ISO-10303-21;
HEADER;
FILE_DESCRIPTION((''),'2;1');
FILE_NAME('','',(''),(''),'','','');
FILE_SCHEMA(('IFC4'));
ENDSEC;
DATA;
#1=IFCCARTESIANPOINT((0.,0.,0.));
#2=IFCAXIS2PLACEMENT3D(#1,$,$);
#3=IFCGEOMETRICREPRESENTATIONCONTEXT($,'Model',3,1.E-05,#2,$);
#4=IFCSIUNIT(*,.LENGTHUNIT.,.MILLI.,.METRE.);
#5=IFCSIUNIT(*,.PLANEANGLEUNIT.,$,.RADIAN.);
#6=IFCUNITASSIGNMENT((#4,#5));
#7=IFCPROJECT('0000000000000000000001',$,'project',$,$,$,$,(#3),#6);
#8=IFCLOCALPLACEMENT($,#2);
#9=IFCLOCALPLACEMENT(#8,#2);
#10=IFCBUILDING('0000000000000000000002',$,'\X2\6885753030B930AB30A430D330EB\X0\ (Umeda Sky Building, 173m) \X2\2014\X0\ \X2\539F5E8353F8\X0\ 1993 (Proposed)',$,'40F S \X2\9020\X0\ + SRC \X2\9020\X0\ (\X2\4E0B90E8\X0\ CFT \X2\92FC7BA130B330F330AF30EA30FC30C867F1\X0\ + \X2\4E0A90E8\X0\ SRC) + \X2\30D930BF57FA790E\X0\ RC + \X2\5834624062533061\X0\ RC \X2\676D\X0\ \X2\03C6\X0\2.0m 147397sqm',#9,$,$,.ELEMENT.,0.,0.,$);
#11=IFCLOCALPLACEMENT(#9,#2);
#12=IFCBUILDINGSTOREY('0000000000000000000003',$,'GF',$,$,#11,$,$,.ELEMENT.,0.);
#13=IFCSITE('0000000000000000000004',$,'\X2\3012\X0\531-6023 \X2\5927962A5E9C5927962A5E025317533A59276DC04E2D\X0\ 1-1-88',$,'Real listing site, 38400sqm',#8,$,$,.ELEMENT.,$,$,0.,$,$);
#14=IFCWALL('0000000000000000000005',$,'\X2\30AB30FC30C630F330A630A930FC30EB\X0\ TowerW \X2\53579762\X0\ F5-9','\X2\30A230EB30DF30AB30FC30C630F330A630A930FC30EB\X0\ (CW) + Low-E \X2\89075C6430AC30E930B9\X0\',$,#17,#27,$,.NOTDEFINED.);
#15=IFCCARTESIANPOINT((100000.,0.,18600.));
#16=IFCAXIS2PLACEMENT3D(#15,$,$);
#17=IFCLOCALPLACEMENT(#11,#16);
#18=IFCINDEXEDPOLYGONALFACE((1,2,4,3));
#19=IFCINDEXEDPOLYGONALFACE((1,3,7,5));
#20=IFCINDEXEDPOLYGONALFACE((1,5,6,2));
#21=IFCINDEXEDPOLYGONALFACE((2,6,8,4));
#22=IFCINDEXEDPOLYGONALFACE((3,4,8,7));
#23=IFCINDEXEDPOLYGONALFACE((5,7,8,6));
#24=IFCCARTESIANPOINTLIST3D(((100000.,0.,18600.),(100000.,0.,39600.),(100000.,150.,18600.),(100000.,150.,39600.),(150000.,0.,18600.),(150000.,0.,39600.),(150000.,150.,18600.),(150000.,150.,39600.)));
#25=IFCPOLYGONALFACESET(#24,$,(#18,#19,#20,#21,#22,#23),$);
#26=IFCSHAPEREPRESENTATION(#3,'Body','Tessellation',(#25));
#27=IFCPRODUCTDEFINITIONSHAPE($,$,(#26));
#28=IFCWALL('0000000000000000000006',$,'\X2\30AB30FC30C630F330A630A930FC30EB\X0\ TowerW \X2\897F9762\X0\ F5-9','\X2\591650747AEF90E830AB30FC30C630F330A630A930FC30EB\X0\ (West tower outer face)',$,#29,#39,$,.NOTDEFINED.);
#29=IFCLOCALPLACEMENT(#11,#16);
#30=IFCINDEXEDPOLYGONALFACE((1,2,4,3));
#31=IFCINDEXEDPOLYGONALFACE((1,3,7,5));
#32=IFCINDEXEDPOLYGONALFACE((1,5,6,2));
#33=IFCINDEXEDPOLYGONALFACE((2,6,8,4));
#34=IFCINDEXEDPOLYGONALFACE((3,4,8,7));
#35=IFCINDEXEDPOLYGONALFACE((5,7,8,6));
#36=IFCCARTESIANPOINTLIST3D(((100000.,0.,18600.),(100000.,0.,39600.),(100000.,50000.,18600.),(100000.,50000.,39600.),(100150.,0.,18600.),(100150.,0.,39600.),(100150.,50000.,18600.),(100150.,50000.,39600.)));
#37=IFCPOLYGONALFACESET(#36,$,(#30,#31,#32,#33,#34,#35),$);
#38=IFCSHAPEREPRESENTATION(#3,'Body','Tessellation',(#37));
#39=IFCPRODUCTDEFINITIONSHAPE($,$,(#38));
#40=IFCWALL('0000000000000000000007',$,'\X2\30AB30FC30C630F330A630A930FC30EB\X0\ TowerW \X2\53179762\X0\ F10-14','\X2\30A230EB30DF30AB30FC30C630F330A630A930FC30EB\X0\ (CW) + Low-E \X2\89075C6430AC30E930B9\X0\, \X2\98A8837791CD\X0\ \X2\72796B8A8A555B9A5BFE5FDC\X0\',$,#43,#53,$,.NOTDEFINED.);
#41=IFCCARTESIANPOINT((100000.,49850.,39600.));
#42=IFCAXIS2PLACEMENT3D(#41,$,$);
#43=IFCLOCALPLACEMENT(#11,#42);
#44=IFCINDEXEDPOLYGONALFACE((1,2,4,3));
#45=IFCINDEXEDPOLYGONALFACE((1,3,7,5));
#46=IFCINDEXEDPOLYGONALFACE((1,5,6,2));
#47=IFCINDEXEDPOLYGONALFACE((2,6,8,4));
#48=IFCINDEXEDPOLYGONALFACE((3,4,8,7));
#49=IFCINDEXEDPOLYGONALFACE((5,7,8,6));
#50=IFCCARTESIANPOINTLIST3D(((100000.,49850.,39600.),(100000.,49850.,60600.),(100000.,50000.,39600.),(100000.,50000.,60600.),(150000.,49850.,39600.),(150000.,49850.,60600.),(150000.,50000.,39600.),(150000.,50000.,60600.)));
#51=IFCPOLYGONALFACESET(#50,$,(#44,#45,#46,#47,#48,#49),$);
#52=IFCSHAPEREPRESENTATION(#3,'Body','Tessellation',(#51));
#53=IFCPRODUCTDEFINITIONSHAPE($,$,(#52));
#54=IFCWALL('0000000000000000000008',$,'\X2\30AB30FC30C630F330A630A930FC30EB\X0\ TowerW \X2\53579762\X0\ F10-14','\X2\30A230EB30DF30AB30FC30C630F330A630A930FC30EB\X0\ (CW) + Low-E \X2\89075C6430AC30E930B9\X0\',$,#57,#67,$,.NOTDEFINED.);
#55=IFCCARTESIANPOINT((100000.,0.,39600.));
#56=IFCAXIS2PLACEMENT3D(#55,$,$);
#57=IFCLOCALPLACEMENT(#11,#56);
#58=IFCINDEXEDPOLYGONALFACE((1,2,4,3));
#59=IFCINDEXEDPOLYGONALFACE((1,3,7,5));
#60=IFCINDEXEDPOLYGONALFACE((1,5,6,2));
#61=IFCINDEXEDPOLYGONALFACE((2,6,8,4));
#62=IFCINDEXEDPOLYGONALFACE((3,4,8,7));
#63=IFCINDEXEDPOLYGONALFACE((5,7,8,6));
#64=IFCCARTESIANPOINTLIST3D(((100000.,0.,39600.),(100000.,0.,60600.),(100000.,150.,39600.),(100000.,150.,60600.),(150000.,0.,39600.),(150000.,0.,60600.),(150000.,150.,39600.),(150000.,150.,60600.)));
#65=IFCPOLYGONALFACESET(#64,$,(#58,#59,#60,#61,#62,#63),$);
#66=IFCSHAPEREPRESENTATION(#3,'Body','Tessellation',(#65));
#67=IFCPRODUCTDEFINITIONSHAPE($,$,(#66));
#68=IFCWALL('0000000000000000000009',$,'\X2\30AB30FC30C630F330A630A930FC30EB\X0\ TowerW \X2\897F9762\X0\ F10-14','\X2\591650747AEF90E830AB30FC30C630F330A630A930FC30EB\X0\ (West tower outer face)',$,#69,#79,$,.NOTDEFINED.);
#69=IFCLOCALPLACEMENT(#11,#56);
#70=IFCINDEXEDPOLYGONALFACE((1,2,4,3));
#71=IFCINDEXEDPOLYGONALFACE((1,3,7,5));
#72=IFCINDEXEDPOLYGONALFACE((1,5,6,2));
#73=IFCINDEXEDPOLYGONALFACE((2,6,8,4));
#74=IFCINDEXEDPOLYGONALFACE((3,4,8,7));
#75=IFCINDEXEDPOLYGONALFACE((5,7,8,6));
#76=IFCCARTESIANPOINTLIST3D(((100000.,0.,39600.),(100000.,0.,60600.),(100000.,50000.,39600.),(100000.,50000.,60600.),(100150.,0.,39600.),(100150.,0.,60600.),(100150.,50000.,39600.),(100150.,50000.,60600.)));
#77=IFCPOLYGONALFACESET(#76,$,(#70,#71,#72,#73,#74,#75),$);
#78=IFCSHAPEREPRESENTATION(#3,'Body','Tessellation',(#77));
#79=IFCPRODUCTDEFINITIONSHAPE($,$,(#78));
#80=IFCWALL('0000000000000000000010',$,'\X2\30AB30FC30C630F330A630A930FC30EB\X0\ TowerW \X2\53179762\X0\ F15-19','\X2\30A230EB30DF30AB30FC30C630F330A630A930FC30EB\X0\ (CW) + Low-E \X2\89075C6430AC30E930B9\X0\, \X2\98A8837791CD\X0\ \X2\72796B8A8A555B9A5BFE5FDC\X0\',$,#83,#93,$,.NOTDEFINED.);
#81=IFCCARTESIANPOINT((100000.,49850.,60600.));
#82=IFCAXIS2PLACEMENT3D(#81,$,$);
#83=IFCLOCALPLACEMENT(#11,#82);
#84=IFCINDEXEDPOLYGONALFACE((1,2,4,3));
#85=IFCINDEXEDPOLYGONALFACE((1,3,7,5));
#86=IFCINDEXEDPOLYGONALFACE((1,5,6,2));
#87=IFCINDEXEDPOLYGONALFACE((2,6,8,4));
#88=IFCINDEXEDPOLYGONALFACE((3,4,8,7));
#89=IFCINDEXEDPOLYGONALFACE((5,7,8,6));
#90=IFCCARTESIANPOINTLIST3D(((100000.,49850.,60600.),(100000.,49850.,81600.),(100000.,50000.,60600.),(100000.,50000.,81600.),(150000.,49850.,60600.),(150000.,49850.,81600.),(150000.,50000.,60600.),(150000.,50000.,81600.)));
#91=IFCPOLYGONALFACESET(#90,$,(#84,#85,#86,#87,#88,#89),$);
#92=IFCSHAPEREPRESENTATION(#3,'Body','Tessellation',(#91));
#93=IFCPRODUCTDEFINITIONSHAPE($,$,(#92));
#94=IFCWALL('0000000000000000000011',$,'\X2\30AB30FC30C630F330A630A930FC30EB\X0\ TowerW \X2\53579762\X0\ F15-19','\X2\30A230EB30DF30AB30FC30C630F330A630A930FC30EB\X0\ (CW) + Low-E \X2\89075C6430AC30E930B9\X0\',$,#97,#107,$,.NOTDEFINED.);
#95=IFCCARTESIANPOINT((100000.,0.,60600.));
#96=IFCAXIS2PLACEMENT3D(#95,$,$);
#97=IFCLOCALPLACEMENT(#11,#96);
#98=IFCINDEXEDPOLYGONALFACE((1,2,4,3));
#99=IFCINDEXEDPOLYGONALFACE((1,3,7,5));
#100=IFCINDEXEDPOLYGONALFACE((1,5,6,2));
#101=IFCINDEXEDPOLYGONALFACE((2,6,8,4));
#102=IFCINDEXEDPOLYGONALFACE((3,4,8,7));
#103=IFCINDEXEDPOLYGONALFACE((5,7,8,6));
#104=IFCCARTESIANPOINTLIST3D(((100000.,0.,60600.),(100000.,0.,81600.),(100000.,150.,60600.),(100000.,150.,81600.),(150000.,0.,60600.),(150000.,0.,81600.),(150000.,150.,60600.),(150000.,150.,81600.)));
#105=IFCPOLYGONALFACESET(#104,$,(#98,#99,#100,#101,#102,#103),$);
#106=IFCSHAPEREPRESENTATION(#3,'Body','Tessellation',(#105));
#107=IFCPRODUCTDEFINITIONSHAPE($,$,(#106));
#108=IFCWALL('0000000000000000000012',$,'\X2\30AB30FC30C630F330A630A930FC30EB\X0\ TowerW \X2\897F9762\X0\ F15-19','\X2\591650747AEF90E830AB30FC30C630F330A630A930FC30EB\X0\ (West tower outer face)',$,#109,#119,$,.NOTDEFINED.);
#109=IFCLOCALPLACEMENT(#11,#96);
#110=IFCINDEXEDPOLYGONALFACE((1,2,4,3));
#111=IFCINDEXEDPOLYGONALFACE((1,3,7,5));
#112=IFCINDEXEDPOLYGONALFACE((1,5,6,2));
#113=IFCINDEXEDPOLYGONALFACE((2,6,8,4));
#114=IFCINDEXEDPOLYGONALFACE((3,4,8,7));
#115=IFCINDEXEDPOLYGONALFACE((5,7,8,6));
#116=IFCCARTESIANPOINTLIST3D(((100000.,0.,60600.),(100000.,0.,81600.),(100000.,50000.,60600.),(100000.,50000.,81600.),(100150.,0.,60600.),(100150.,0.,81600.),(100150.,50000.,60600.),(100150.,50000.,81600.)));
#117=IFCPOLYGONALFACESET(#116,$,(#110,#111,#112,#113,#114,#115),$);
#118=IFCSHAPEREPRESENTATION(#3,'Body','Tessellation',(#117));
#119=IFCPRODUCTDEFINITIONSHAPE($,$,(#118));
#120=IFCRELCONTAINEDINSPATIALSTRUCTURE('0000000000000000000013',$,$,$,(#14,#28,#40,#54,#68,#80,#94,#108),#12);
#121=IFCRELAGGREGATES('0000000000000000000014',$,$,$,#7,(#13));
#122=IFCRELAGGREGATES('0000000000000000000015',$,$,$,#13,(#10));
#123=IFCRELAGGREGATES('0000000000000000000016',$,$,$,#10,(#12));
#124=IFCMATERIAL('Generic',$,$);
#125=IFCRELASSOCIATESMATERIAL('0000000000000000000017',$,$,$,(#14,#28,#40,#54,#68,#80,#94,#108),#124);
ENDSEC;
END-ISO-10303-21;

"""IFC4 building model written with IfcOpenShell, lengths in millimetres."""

from ifc_helpers import new_model, si_unit, frame, frame_2d, origin, place, context, project, spatial, rectangle, extrude, material, element, save


model = new_model("IFC4")

# Units and contexts
model_context = context("Model", 3, precision=1e-05, world=origin())
ifc_project = project(units=[si_unit("LENGTHUNIT", "METRE", prefix="MILLI"), si_unit("PLANEANGLEUNIT", "RADIAN")], contexts=[model_context])

# Site, building, storey
site_placement = place(None, origin())
site = spatial("IfcSite", under=ifc_project, at=site_placement, Name="〒531-6023 大阪府大阪市北区大淀中 1-1-88", ObjectType="Real listing site, 38400sqm", CompositionType="ELEMENT", RefElevation=0.0)
building_placement = place(site_placement, origin())
building = spatial("IfcBuilding", under=site, at=building_placement, Name="梅田スカイビル (Umeda Sky Building, 173m) — 原広司 1993 (Proposed)", ObjectType="40F S 造 + SRC 造 (下部 CFT 鋼管コンクリート柱 + 上部 SRC) + ベタ基礎 RC + 場所打ち RC 杭 φ2.0m 147397sqm", CompositionType="ELEMENT", ElevationOfRefHeight=0.0, ElevationOfTerrain=0.0)
storey_placement = place(building_placement, origin())
storey = spatial("IfcBuildingStorey", under=building, at=storey_placement, Name="GF", CompositionType="ELEMENT", Elevation=0.0)

# Walls
ifc_material_1 = material(Name="Generic")
wall_1_placement = place(storey_placement, frame((100000.0, 0.0, 18600.0)))
element("IfcWall", 1, at=wall_1_placement, inside=storey, material=ifc_material_1, Name="カーテンウォール TowerW 南面 F5-9", Description="アルミカーテンウォール (CW) + Low-E 複層ガラス", PredefinedType="NOTDEFINED", context=model_context, shape_type="SweptSolid", body=[
    extrude(rectangle(XDim=50000.0, YDim=150.0, at=frame_2d((25000.0, 75.0))), frame((100000.0, 0.0, 18600.0)), (0.0, 0.0, 1.0), 21000.0),
])
wall_2_placement = place(storey_placement, frame((100000.0, 0.0, 18600.0)))
element("IfcWall", 2, at=wall_2_placement, inside=storey, material=ifc_material_1, Name="カーテンウォール TowerW 西面 F5-9", Description="外側端部カーテンウォール (West tower outer face)", PredefinedType="NOTDEFINED", context=model_context, shape_type="SweptSolid", body=[
    extrude(rectangle(XDim=150.0, YDim=50000.0, at=frame_2d((75.0, 25000.0))), frame((100000.0, 0.0, 18600.0)), (0.0, 0.0, 1.0), 21000.0),
])
wall_3_placement = place(storey_placement, frame((100000.0, 49850.0, 39600.0)))
element("IfcWall", 3, at=wall_3_placement, inside=storey, material=ifc_material_1, Name="カーテンウォール TowerW 北面 F10-14", Description="アルミカーテンウォール (CW) + Low-E 複層ガラス, 風荷重 特殊評定対応", PredefinedType="NOTDEFINED", context=model_context, shape_type="SweptSolid", body=[
    extrude(rectangle(XDim=50000.0, YDim=150.0, at=frame_2d((25000.0, 75.0))), frame((100000.0, 49850.0, 39600.0)), (0.0, 0.0, 1.0), 21000.0),
])
wall_4_placement = place(storey_placement, frame((100000.0, 0.0, 39600.0)))
element("IfcWall", 4, at=wall_4_placement, inside=storey, material=ifc_material_1, Name="カーテンウォール TowerW 南面 F10-14", Description="アルミカーテンウォール (CW) + Low-E 複層ガラス", PredefinedType="NOTDEFINED", context=model_context, shape_type="SweptSolid", body=[
    extrude(rectangle(XDim=50000.0, YDim=150.0, at=frame_2d((25000.0, 75.0))), frame((100000.0, 0.0, 39600.0)), (0.0, 0.0, 1.0), 21000.0),
])
wall_5_placement = place(storey_placement, frame((100000.0, 0.0, 39600.0)))
element("IfcWall", 5, at=wall_5_placement, inside=storey, material=ifc_material_1, Name="カーテンウォール TowerW 西面 F10-14", Description="外側端部カーテンウォール (West tower outer face)", PredefinedType="NOTDEFINED", context=model_context, shape_type="SweptSolid", body=[
    extrude(rectangle(XDim=150.0, YDim=50000.0, at=frame_2d((75.0, 25000.0))), frame((100000.0, 0.0, 39600.0)), (0.0, 0.0, 1.0), 21000.0),
])
wall_6_placement = place(storey_placement, frame((100000.0, 49850.0, 60600.0)))
element("IfcWall", 6, at=wall_6_placement, inside=storey, material=ifc_material_1, Name="カーテンウォール TowerW 北面 F15-19", Description="アルミカーテンウォール (CW) + Low-E 複層ガラス, 風荷重 特殊評定対応", PredefinedType="NOTDEFINED", context=model_context, shape_type="SweptSolid", body=[
    extrude(rectangle(XDim=50000.0, YDim=150.0, at=frame_2d((25000.0, 75.0))), frame((100000.0, 49850.0, 60600.0)), (0.0, 0.0, 1.0), 21000.0),
])
wall_7_placement = place(storey_placement, frame((100000.0, 0.0, 60600.0)))
element("IfcWall", 7, at=wall_7_placement, inside=storey, material=ifc_material_1, Name="カーテンウォール TowerW 南面 F15-19", Description="アルミカーテンウォール (CW) + Low-E 複層ガラス", PredefinedType="NOTDEFINED", context=model_context, shape_type="SweptSolid", body=[
    extrude(rectangle(XDim=50000.0, YDim=150.0, at=frame_2d((25000.0, 75.0))), frame((100000.0, 0.0, 60600.0)), (0.0, 0.0, 1.0), 21000.0),
])
wall_8_placement = place(storey_placement, frame((100000.0, 0.0, 60600.0)))
element("IfcWall", 8, at=wall_8_placement, inside=storey, material=ifc_material_1, Name="カーテンウォール TowerW 西面 F15-19", Description="外側端部カーテンウォール (West tower outer face)", PredefinedType="NOTDEFINED", context=model_context, shape_type="SweptSolid", body=[
    extrude(rectangle(XDim=150.0, YDim=50000.0, at=frame_2d((75.0, 25000.0))), frame((100000.0, 0.0, 60600.0)), (0.0, 0.0, 1.0), 21000.0),
])

save(model, "model.ifc")
